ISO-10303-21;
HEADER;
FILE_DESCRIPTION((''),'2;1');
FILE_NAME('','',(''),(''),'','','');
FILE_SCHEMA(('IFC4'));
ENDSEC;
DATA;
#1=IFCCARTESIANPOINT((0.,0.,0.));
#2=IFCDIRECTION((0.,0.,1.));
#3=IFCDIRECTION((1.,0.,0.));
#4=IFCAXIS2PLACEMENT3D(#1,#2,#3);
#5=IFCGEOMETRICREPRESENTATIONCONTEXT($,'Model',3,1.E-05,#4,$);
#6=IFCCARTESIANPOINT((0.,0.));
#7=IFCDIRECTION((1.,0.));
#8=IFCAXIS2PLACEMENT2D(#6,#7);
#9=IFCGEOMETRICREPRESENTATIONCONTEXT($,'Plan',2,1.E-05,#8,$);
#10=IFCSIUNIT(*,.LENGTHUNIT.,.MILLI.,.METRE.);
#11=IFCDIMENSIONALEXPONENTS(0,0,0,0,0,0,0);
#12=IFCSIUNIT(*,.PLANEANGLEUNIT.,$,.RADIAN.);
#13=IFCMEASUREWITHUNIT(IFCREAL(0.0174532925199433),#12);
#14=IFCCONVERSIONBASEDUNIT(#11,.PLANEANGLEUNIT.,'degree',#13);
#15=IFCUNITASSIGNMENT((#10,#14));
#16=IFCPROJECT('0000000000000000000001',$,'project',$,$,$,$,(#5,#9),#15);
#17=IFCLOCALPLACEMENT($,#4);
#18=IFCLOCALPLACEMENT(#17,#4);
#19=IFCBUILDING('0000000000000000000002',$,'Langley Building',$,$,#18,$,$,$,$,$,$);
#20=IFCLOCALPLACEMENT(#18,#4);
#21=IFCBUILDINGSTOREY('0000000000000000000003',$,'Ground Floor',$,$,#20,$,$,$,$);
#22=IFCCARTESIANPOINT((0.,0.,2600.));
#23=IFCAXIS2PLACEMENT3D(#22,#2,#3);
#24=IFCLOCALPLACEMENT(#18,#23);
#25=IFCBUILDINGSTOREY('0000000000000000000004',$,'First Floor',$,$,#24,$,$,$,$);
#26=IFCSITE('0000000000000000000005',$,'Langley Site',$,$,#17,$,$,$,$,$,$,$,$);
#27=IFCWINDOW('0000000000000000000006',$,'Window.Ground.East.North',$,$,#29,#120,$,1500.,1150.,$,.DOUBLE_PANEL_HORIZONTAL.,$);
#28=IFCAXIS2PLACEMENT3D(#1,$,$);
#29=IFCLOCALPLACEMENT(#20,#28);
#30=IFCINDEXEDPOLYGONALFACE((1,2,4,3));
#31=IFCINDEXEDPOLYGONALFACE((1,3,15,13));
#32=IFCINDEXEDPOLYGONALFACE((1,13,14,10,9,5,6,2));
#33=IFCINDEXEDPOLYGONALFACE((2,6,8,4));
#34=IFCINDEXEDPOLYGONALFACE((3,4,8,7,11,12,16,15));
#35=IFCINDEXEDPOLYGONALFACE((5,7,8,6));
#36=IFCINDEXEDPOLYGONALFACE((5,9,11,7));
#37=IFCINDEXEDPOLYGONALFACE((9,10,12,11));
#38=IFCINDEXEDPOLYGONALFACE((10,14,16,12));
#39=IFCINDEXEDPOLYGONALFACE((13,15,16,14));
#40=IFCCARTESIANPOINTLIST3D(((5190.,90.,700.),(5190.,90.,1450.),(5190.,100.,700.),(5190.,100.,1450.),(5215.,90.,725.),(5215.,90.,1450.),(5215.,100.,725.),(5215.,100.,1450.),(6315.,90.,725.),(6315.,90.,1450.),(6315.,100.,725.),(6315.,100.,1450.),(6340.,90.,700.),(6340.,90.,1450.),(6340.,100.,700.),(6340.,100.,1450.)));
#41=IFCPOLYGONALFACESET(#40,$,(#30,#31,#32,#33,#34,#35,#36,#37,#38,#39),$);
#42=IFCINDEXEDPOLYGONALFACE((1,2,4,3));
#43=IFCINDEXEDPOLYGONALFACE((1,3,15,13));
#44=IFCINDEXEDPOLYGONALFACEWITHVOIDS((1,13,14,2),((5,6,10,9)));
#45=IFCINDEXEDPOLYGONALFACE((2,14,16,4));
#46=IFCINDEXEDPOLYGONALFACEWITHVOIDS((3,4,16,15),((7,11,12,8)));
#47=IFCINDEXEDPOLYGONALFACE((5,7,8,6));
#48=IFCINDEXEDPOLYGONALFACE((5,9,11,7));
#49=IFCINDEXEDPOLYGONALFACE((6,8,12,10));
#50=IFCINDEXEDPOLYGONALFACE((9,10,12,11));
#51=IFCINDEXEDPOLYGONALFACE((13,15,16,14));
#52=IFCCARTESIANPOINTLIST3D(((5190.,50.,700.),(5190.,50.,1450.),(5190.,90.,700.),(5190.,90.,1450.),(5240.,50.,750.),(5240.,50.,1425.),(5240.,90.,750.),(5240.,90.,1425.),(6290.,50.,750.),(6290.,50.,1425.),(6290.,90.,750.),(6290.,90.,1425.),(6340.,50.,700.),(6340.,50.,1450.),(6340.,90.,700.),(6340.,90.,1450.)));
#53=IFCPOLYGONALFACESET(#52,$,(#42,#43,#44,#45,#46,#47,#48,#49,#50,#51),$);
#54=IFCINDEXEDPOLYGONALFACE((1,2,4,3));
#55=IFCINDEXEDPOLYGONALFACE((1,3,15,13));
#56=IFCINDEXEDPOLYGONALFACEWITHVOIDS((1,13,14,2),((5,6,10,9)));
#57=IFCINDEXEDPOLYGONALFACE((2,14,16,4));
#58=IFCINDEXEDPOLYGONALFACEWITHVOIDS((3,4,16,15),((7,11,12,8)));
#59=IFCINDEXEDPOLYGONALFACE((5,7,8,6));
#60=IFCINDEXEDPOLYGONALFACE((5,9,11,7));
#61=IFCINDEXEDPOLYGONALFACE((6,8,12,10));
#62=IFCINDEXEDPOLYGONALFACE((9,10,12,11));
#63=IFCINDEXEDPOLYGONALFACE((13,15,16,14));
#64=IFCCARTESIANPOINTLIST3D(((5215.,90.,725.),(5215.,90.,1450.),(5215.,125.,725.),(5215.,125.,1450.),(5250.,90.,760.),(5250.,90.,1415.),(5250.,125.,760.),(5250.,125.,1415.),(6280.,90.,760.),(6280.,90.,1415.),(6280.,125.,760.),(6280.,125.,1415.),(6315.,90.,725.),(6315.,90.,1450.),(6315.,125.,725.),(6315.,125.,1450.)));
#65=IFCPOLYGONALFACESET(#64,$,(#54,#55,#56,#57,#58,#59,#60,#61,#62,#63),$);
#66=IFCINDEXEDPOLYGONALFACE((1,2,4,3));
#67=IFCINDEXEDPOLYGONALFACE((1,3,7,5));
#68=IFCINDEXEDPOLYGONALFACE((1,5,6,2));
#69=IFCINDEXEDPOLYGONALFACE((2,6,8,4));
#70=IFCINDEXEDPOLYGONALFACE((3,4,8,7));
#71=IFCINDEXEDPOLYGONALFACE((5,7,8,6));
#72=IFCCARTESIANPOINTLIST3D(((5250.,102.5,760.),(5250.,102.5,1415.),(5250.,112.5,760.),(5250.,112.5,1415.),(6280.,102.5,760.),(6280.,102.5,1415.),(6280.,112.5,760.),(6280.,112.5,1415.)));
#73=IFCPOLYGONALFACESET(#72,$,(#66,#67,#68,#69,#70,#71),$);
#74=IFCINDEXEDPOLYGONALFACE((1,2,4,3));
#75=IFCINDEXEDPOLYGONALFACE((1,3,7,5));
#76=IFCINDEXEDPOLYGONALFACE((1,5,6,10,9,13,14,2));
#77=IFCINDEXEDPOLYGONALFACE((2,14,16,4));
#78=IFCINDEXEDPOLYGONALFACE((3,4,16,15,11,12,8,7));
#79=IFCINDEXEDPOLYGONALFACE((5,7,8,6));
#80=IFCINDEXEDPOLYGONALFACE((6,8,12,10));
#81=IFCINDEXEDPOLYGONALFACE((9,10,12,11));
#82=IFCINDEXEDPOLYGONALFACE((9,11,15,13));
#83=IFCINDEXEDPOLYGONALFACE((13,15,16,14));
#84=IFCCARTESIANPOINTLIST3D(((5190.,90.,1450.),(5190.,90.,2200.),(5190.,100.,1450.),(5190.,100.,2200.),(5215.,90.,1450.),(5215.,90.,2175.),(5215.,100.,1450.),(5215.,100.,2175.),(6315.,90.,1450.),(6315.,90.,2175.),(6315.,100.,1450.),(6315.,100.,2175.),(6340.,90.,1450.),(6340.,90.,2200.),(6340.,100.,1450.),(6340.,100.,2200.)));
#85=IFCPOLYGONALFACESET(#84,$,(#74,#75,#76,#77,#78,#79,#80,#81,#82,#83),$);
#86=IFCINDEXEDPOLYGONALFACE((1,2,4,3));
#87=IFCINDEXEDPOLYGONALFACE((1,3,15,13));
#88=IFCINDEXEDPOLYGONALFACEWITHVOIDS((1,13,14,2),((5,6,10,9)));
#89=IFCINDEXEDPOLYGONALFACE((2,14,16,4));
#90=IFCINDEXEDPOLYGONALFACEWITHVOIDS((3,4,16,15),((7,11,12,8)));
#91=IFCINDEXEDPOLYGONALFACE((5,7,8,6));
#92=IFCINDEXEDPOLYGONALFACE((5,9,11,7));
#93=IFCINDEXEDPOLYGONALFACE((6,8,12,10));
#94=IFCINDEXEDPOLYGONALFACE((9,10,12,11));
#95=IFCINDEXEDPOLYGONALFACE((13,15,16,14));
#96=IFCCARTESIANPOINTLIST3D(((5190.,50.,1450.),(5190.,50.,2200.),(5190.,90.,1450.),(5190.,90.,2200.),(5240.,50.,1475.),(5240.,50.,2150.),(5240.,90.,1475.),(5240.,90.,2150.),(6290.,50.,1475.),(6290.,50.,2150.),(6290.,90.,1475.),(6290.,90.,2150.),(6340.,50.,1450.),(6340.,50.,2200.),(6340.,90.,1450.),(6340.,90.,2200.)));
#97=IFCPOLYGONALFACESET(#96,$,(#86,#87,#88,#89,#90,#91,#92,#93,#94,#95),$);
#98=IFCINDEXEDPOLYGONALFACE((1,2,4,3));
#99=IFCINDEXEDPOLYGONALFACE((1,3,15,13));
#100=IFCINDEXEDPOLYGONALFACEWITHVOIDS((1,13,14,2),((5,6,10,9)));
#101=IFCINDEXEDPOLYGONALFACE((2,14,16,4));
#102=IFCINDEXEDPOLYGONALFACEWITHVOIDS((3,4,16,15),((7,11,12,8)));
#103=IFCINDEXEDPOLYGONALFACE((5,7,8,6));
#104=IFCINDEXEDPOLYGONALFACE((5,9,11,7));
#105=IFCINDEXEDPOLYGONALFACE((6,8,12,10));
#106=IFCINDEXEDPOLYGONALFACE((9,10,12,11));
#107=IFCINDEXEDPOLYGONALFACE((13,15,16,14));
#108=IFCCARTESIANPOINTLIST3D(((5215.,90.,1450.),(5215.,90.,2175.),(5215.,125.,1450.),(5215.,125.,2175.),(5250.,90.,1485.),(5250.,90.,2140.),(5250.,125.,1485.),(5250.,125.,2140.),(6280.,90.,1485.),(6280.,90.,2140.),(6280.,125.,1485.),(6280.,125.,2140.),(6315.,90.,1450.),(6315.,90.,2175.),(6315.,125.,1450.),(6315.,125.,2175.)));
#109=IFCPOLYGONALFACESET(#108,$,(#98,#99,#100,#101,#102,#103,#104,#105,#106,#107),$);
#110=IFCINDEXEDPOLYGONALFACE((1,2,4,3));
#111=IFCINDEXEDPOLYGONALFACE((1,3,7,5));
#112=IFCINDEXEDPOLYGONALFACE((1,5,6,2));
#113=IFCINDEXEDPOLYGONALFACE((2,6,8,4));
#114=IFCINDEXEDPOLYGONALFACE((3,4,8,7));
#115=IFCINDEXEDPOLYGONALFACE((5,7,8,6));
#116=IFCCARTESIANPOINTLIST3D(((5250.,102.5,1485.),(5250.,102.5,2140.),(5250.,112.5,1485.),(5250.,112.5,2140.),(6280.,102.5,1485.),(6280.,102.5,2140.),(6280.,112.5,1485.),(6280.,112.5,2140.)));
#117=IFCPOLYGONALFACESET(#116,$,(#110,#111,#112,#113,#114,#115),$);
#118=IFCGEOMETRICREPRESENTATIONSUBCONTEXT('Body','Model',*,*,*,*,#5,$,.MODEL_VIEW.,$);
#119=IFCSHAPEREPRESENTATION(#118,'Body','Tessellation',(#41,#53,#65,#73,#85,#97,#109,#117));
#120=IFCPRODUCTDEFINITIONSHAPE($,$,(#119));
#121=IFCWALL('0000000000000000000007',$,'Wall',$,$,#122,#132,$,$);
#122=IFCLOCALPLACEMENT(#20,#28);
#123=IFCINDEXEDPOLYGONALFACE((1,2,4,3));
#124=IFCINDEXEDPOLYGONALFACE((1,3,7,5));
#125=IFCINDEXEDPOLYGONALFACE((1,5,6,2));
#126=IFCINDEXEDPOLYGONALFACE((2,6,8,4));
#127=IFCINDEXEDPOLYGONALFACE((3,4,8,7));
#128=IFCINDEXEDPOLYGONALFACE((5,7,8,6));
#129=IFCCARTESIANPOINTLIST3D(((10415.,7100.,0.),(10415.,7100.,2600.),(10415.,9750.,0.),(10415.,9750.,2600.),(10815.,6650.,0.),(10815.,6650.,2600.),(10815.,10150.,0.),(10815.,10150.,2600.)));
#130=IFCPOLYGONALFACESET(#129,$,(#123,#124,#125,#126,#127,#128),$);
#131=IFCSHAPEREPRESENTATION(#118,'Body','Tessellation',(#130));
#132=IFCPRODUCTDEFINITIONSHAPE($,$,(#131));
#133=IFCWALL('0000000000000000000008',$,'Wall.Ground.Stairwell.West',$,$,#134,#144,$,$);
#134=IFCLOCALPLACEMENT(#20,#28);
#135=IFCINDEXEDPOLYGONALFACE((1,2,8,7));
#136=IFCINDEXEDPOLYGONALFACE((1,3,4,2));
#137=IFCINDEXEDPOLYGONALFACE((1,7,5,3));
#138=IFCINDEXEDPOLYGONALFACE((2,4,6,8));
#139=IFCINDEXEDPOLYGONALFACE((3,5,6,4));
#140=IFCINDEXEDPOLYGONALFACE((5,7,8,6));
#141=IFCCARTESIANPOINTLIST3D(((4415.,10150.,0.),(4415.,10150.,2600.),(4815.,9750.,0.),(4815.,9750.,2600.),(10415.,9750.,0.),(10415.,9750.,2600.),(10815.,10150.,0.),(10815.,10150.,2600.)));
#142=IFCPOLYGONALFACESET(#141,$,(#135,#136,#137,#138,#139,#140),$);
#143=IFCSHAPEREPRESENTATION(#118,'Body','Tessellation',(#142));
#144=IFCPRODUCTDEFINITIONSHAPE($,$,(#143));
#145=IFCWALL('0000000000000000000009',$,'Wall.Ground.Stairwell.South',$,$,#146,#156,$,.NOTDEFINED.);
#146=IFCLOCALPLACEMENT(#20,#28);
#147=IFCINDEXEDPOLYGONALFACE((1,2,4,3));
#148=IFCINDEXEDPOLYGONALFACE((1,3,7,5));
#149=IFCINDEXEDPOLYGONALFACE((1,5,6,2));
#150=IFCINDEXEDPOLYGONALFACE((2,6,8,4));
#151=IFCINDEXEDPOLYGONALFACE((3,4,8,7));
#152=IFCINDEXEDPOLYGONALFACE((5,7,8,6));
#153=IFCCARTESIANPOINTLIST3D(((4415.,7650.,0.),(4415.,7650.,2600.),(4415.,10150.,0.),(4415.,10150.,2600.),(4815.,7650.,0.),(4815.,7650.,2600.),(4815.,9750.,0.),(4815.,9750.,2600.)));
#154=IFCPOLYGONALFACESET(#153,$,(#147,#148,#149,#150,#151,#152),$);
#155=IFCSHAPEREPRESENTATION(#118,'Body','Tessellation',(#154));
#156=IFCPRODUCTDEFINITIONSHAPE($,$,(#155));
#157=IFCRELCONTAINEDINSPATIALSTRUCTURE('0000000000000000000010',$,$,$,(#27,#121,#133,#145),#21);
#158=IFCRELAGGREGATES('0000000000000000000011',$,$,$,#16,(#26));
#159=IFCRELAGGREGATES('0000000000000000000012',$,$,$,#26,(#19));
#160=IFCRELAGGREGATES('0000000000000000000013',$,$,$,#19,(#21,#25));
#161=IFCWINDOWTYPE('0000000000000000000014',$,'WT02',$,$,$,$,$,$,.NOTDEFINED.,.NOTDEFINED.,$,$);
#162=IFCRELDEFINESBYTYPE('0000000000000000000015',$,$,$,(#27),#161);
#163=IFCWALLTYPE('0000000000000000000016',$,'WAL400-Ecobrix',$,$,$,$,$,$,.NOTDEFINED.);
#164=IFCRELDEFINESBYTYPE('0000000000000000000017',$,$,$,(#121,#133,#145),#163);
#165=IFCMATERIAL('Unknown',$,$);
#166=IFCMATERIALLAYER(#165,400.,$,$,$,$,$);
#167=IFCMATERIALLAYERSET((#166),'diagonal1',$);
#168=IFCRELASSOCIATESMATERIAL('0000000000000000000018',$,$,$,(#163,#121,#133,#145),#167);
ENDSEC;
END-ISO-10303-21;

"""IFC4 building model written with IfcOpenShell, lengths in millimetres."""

from ifc_helpers import new_model, entity, si_unit, converted_unit, frame, origin_with_axes, origin_2d_with_axis, place, context, subcontext, project, spatial, line, indexed_curve, outline, extrude, shape, source, transform, mapped, material, layer, layer_set, layer_usage, type_object, type_shapes, element, save


model = new_model("IFC4")

# Units and contexts
model_context = context("Model", 3, precision=1e-05, world=origin_with_axes())
plan_context = context("Plan", 2, precision=1e-05, world=origin_2d_with_axis())
body_context_1 = subcontext(model_context, "Body", "Model", "MODEL_VIEW")
body_context_2 = subcontext(plan_context, "Body", "Plan", "PLAN_VIEW")
ifc_project = project(units=[si_unit("LENGTHUNIT", "METRE", prefix="MILLI"), converted_unit("PLANEANGLEUNIT", "degree", entity("IfcReal", 0.0174532925199433), si_unit("PLANEANGLEUNIT", "RADIAN"), dimensions=[0, 0, 0, 0, 0, 0, 0])], contexts=[model_context, plan_context])

# Site, building, storey
site_placement = place(None, origin_with_axes())
site = spatial("IfcSite", under=ifc_project, at=site_placement, Name="Langley Site")
building_placement = place(site_placement, origin_with_axes())
building = spatial("IfcBuilding", under=site, at=building_placement, Name="Langley Building")
storey_1_placement = place(building_placement, origin_with_axes())
storey_1 = spatial("IfcBuildingStorey", under=building, at=storey_1_placement, Name="Ground Floor")

# Shared definitions
ifc_material = material(Name="Unknown")

# Shared definitions
storey_2_placement = place(building_placement, frame((0.0, 0.0, 2600.0), z_axis=(0.0, 0.0, 1.0), x_axis=(1.0, 0.0, 0.0)))
storey_2 = spatial("IfcBuildingStorey", under=building, at=storey_2_placement, Name="First Floor")

# Window
window_type_1 = type_object("IfcWindowType", Name="WT02", PartitioningType="NOTDEFINED", PredefinedType="NOTDEFINED")
shared_shape_1 = source(origin_with_axes(), body_context_1, "Body", "SweptSolid", [
    extrude(outline(indexed_curve([(1150.0, 750.0), (1150.0, 0.0), (0.0, 0.0), (0.0, 750.0), (25.0, 750.0), (25.0, 25.0), (1125.0, 25.0), (1125.0, 750.0)], segments=[line(1, 2, 3, 4, 5, 6, 7, 8, 1)])), frame((0.0, 90.0, 0.0), z_axis=(0.0, -1.0, 0.0), x_axis=(1.0, 0.0, 0.0)), (0.0, 0.0, -1.0), 10.0),
    extrude(outline(indexed_curve([(0.0, 0.0), (1150.0, 0.0), (1150.0, 750.0), (0.0, 750.0)], segments=[line(1, 2, 3, 4, 1)]), holes=[indexed_curve([(50.0, 50.0), (1100.0, 50.0), (1100.0, 725.0), (50.0, 725.0)], segments=[line(1, 2, 3, 4, 1)])]), frame((0.0, 50.0, 0.0), z_axis=(0.0, -1.0, 0.0), x_axis=(1.0, 0.0, 0.0)), (0.0, 0.0, -1.0), 40.0),
    extrude(outline(indexed_curve([(0.0, 0.0), (1100.0, 0.0), (1100.0, 725.0), (0.0, 725.0)], segments=[line(1, 2, 3, 4, 1)]), holes=[indexed_curve([(35.0, 35.0), (1065.0, 35.0), (1065.0, 690.0), (35.0, 690.0)], segments=[line(1, 2, 3, 4, 1)])]), frame((25.0, 90.0, 25.0), z_axis=(0.0, -1.0, 0.0), x_axis=(1.0, 0.0, 0.0)), (0.0, 0.0, -1.0), 35.0),
    extrude(outline(indexed_curve([(35.0, 35.0), (1065.0, 35.0), (1065.0, 690.0), (35.0, 690.0)], segments=[line(1, 2, 3, 4, 1)])), frame((25.0, 102.5, 25.0), z_axis=(0.0, -1.0, 0.0), x_axis=(1.0, 0.0, 0.0)), (0.0, 0.0, -1.0), 10.0),
    extrude(outline(indexed_curve([(0.0, 0.0), (0.0, 750.0), (1150.0, 750.0), (1150.0, 0.0), (1125.0, 0.0), (1125.0, 725.0), (25.0, 725.0), (25.0, 0.0)], segments=[line(1, 2, 3, 4, 5, 6, 7, 8, 1)])), frame((0.0, 90.0, 750.0), z_axis=(0.0, -1.0, 0.0), x_axis=(1.0, 0.0, 0.0)), (0.0, 0.0, -1.0), 10.0),
    extrude(outline(indexed_curve([(0.0, 0.0), (1150.0, 0.0), (1150.0, 750.0), (0.0, 750.0)], segments=[line(1, 2, 3, 4, 1)]), holes=[indexed_curve([(50.0, 25.0), (1100.0, 25.0), (1100.0, 700.0), (50.0, 700.0)], segments=[line(1, 2, 3, 4, 1)])]), frame((0.0, 50.0, 750.0), z_axis=(0.0, -1.0, 0.0), x_axis=(1.0, 0.0, 0.0)), (0.0, 0.0, -1.0), 40.0),
    extrude(outline(indexed_curve([(0.0, 0.0), (1100.0, 0.0), (1100.0, 725.0), (0.0, 725.0)], segments=[line(1, 2, 3, 4, 1)]), holes=[indexed_curve([(35.0, 35.0), (1065.0, 35.0), (1065.0, 690.0), (35.0, 690.0)], segments=[line(1, 2, 3, 4, 1)])]), frame((25.0, 90.0, 750.0), z_axis=(0.0, -1.0, 0.0), x_axis=(1.0, 0.0, 0.0)), (0.0, 0.0, -1.0), 35.0),
    extrude(outline(indexed_curve([(35.0, 35.0), (1065.0, 35.0), (1065.0, 690.0), (35.0, 690.0)], segments=[line(1, 2, 3, 4, 1)])), frame((25.0, 102.5, 750.0), z_axis=(0.0, -1.0, 0.0), x_axis=(1.0, 0.0, 0.0)), (0.0, 0.0, -1.0), 10.0),
])
shared_shape_2 = source(origin_with_axes(), body_context_2, "Body", "Curve2D", [
    entity("IfcIndexedPolyCurve", entity("IfcCartesianPointList2D", [[50.0, 50.0], [1100.0, 50.0]])),
    entity("IfcIndexedPolyCurve", entity("IfcCartesianPointList2D", [[0.0, 100.0], [25.0, 100.0], [25.0, 90.0], [50.0, 90.0], [50.0, 50.0], [0.0, 50.0]]), [entity("IfcLineIndex", [1, 2, 3, 4, 5, 6, 1])]),
    entity("IfcIndexedPolyCurve", entity("IfcCartesianPointList2D", [[1150.0, 100.0], [1125.0, 100.0], [1125.0, 90.0], [1100.0, 90.0], [1100.0, 50.0], [1150.0, 50.0]]), [entity("IfcLineIndex", [1, 2, 3, 4, 5, 6, 1])]),
    entity("IfcIndexedPolyCurve", entity("IfcCartesianPointList2D", [[25.0, 90.0], [60.0, 90.0], [60.0, 125.0], [25.0, 125.0]]), [entity("IfcLineIndex", [1, 2, 3, 4, 1])]),
    entity("IfcIndexedPolyCurve", entity("IfcCartesianPointList2D", [[1125.0, 90.0], [1090.0, 90.0], [1090.0, 125.0], [1125.0, 125.0]]), [entity("IfcLineIndex", [1, 2, 3, 4, 1])]),
    entity("IfcIndexedPolyCurve", entity("IfcCartesianPointList2D", [[60.0, 90.0], [1090.0, 90.0]])),
    entity("IfcIndexedPolyCurve", entity("IfcCartesianPointList2D", [[60.0, 125.0], [1090.0, 125.0]])),
    entity("IfcIndexedPolyCurve", entity("IfcCartesianPointList2D", [[60.0, 107.5], [1090.0, 107.5]])),
])
type_shapes(window_type_1, [shared_shape_1, shared_shape_2])
window_1_placement = place(storey_1_placement, frame((5190.0, 0.0, 700.0), z_axis=(0.0, 0.0, 1.0), x_axis=(1.0, 0.0, 0.0)))
element("IfcWindow", 1, at=window_1_placement, inside=storey_1, type_object=window_type_1, Name="Window.Ground.East.North", OverallHeight=1500.0, OverallWidth=1150.0, PartitioningType="DOUBLE_PANEL_HORIZONTAL", shapes=[
    shape(body_context_1, "Body", "MappedRepresentation", [mapped(shared_shape_1, transform((0.0, 0.0, 0.0), x_axis=(1.0, 0.0, 0.0), y_axis=(0.0, 1.0, 0.0), z_axis=(0.0, 0.0, 1.0), scale=1.0))]),
    shape(body_context_2, "Body", "MappedRepresentation", [mapped(shared_shape_2, transform((0.0, 0.0, 0.0), x_axis=(1.0, 0.0, 0.0), y_axis=(0.0, 1.0, 0.0), z_axis=(0.0, 0.0, 1.0), scale=1.0))]),
])

# Walls
ifc_layer_1 = layer(ifc_material, 400.0)
ifc_layer_set_1 = layer_set([ifc_layer_1], Name="diagonal1")
ifc_layer_usage_1 = layer_usage(ifc_layer_set_1, "AXIS2", "POSITIVE", 0.0)
wall_type_1 = type_object("IfcWallType", Name="WAL400-Ecobrix", PredefinedType="NOTDEFINED", material=ifc_layer_set_1)
wall_1_placement = place(storey_1_placement, frame((10815.0, 7100.0, 0.0), z_axis=(0.0, 0.0, 1.0), x_axis=(-0.000001, 1.0, 0.0)))
element("IfcWall", 2, at=wall_1_placement, inside=storey_1, type_object=wall_type_1, material=ifc_layer_usage_1, Name="Wall", context=body_context_1, shape_type="SweptSolid", body=[
    extrude(outline(indexed_curve([(-450.0, 0.0), (0.0, 400.0), (2650.0, 400.0), (3050.0, 0.0)], segments=[line(1, 2, 3, 4, 1)])), origin_with_axes(), (0.0, 0.0, 1.0), 2600.0),
])
ifc_layer_usage_2 = layer_usage(ifc_layer_set_1, "AXIS2", "POSITIVE", 0.0)
wall_2_placement = place(storey_1_placement, frame((10815.0, 10150.0, 0.0), z_axis=(0.0, 0.0, 1.0), x_axis=(-1.0, 0.0, 0.0)))
element("IfcWall", 3, at=wall_2_placement, inside=storey_1, type_object=wall_type_1, material=ifc_layer_usage_2, Name="Wall.Ground.Stairwell.West", context=body_context_1, shape_type="SweptSolid", body=[
    extrude(outline(indexed_curve([(0.0, 0.0), (400.0, 400.0), (6000.0, 400.0), (6400.0, 0.0)], segments=[line(1, 2, 3, 4, 1)])), origin_with_axes(), (0.0, 0.0, 1.0), 2600.0),
])
ifc_layer_usage_3 = layer_usage(ifc_layer_set_1, "AXIS2", "POSITIVE", 0.0)
wall_3_placement = place(storey_1_placement, frame((4415.0, 10150.0, 0.0), z_axis=(0.0, 0.0, 1.0), x_axis=(0.0, -1.0, 0.0)))
element("IfcWall", 4, at=wall_3_placement, inside=storey_1, type_object=wall_type_1, material=ifc_layer_usage_3, Name="Wall.Ground.Stairwell.South", PredefinedType="NOTDEFINED", context=body_context_1, shape_type="SweptSolid", body=[
    extrude(outline(indexed_curve([(0.0, 0.0), (400.0, 400.0), (2500.0, 400.0), (2500.0, 0.0)], segments=[line(1, 2, 3, 4, 1)])), origin_with_axes(), (0.0, 0.0, 1.0), 2600.0),
])

save(model, "model.ifc")
